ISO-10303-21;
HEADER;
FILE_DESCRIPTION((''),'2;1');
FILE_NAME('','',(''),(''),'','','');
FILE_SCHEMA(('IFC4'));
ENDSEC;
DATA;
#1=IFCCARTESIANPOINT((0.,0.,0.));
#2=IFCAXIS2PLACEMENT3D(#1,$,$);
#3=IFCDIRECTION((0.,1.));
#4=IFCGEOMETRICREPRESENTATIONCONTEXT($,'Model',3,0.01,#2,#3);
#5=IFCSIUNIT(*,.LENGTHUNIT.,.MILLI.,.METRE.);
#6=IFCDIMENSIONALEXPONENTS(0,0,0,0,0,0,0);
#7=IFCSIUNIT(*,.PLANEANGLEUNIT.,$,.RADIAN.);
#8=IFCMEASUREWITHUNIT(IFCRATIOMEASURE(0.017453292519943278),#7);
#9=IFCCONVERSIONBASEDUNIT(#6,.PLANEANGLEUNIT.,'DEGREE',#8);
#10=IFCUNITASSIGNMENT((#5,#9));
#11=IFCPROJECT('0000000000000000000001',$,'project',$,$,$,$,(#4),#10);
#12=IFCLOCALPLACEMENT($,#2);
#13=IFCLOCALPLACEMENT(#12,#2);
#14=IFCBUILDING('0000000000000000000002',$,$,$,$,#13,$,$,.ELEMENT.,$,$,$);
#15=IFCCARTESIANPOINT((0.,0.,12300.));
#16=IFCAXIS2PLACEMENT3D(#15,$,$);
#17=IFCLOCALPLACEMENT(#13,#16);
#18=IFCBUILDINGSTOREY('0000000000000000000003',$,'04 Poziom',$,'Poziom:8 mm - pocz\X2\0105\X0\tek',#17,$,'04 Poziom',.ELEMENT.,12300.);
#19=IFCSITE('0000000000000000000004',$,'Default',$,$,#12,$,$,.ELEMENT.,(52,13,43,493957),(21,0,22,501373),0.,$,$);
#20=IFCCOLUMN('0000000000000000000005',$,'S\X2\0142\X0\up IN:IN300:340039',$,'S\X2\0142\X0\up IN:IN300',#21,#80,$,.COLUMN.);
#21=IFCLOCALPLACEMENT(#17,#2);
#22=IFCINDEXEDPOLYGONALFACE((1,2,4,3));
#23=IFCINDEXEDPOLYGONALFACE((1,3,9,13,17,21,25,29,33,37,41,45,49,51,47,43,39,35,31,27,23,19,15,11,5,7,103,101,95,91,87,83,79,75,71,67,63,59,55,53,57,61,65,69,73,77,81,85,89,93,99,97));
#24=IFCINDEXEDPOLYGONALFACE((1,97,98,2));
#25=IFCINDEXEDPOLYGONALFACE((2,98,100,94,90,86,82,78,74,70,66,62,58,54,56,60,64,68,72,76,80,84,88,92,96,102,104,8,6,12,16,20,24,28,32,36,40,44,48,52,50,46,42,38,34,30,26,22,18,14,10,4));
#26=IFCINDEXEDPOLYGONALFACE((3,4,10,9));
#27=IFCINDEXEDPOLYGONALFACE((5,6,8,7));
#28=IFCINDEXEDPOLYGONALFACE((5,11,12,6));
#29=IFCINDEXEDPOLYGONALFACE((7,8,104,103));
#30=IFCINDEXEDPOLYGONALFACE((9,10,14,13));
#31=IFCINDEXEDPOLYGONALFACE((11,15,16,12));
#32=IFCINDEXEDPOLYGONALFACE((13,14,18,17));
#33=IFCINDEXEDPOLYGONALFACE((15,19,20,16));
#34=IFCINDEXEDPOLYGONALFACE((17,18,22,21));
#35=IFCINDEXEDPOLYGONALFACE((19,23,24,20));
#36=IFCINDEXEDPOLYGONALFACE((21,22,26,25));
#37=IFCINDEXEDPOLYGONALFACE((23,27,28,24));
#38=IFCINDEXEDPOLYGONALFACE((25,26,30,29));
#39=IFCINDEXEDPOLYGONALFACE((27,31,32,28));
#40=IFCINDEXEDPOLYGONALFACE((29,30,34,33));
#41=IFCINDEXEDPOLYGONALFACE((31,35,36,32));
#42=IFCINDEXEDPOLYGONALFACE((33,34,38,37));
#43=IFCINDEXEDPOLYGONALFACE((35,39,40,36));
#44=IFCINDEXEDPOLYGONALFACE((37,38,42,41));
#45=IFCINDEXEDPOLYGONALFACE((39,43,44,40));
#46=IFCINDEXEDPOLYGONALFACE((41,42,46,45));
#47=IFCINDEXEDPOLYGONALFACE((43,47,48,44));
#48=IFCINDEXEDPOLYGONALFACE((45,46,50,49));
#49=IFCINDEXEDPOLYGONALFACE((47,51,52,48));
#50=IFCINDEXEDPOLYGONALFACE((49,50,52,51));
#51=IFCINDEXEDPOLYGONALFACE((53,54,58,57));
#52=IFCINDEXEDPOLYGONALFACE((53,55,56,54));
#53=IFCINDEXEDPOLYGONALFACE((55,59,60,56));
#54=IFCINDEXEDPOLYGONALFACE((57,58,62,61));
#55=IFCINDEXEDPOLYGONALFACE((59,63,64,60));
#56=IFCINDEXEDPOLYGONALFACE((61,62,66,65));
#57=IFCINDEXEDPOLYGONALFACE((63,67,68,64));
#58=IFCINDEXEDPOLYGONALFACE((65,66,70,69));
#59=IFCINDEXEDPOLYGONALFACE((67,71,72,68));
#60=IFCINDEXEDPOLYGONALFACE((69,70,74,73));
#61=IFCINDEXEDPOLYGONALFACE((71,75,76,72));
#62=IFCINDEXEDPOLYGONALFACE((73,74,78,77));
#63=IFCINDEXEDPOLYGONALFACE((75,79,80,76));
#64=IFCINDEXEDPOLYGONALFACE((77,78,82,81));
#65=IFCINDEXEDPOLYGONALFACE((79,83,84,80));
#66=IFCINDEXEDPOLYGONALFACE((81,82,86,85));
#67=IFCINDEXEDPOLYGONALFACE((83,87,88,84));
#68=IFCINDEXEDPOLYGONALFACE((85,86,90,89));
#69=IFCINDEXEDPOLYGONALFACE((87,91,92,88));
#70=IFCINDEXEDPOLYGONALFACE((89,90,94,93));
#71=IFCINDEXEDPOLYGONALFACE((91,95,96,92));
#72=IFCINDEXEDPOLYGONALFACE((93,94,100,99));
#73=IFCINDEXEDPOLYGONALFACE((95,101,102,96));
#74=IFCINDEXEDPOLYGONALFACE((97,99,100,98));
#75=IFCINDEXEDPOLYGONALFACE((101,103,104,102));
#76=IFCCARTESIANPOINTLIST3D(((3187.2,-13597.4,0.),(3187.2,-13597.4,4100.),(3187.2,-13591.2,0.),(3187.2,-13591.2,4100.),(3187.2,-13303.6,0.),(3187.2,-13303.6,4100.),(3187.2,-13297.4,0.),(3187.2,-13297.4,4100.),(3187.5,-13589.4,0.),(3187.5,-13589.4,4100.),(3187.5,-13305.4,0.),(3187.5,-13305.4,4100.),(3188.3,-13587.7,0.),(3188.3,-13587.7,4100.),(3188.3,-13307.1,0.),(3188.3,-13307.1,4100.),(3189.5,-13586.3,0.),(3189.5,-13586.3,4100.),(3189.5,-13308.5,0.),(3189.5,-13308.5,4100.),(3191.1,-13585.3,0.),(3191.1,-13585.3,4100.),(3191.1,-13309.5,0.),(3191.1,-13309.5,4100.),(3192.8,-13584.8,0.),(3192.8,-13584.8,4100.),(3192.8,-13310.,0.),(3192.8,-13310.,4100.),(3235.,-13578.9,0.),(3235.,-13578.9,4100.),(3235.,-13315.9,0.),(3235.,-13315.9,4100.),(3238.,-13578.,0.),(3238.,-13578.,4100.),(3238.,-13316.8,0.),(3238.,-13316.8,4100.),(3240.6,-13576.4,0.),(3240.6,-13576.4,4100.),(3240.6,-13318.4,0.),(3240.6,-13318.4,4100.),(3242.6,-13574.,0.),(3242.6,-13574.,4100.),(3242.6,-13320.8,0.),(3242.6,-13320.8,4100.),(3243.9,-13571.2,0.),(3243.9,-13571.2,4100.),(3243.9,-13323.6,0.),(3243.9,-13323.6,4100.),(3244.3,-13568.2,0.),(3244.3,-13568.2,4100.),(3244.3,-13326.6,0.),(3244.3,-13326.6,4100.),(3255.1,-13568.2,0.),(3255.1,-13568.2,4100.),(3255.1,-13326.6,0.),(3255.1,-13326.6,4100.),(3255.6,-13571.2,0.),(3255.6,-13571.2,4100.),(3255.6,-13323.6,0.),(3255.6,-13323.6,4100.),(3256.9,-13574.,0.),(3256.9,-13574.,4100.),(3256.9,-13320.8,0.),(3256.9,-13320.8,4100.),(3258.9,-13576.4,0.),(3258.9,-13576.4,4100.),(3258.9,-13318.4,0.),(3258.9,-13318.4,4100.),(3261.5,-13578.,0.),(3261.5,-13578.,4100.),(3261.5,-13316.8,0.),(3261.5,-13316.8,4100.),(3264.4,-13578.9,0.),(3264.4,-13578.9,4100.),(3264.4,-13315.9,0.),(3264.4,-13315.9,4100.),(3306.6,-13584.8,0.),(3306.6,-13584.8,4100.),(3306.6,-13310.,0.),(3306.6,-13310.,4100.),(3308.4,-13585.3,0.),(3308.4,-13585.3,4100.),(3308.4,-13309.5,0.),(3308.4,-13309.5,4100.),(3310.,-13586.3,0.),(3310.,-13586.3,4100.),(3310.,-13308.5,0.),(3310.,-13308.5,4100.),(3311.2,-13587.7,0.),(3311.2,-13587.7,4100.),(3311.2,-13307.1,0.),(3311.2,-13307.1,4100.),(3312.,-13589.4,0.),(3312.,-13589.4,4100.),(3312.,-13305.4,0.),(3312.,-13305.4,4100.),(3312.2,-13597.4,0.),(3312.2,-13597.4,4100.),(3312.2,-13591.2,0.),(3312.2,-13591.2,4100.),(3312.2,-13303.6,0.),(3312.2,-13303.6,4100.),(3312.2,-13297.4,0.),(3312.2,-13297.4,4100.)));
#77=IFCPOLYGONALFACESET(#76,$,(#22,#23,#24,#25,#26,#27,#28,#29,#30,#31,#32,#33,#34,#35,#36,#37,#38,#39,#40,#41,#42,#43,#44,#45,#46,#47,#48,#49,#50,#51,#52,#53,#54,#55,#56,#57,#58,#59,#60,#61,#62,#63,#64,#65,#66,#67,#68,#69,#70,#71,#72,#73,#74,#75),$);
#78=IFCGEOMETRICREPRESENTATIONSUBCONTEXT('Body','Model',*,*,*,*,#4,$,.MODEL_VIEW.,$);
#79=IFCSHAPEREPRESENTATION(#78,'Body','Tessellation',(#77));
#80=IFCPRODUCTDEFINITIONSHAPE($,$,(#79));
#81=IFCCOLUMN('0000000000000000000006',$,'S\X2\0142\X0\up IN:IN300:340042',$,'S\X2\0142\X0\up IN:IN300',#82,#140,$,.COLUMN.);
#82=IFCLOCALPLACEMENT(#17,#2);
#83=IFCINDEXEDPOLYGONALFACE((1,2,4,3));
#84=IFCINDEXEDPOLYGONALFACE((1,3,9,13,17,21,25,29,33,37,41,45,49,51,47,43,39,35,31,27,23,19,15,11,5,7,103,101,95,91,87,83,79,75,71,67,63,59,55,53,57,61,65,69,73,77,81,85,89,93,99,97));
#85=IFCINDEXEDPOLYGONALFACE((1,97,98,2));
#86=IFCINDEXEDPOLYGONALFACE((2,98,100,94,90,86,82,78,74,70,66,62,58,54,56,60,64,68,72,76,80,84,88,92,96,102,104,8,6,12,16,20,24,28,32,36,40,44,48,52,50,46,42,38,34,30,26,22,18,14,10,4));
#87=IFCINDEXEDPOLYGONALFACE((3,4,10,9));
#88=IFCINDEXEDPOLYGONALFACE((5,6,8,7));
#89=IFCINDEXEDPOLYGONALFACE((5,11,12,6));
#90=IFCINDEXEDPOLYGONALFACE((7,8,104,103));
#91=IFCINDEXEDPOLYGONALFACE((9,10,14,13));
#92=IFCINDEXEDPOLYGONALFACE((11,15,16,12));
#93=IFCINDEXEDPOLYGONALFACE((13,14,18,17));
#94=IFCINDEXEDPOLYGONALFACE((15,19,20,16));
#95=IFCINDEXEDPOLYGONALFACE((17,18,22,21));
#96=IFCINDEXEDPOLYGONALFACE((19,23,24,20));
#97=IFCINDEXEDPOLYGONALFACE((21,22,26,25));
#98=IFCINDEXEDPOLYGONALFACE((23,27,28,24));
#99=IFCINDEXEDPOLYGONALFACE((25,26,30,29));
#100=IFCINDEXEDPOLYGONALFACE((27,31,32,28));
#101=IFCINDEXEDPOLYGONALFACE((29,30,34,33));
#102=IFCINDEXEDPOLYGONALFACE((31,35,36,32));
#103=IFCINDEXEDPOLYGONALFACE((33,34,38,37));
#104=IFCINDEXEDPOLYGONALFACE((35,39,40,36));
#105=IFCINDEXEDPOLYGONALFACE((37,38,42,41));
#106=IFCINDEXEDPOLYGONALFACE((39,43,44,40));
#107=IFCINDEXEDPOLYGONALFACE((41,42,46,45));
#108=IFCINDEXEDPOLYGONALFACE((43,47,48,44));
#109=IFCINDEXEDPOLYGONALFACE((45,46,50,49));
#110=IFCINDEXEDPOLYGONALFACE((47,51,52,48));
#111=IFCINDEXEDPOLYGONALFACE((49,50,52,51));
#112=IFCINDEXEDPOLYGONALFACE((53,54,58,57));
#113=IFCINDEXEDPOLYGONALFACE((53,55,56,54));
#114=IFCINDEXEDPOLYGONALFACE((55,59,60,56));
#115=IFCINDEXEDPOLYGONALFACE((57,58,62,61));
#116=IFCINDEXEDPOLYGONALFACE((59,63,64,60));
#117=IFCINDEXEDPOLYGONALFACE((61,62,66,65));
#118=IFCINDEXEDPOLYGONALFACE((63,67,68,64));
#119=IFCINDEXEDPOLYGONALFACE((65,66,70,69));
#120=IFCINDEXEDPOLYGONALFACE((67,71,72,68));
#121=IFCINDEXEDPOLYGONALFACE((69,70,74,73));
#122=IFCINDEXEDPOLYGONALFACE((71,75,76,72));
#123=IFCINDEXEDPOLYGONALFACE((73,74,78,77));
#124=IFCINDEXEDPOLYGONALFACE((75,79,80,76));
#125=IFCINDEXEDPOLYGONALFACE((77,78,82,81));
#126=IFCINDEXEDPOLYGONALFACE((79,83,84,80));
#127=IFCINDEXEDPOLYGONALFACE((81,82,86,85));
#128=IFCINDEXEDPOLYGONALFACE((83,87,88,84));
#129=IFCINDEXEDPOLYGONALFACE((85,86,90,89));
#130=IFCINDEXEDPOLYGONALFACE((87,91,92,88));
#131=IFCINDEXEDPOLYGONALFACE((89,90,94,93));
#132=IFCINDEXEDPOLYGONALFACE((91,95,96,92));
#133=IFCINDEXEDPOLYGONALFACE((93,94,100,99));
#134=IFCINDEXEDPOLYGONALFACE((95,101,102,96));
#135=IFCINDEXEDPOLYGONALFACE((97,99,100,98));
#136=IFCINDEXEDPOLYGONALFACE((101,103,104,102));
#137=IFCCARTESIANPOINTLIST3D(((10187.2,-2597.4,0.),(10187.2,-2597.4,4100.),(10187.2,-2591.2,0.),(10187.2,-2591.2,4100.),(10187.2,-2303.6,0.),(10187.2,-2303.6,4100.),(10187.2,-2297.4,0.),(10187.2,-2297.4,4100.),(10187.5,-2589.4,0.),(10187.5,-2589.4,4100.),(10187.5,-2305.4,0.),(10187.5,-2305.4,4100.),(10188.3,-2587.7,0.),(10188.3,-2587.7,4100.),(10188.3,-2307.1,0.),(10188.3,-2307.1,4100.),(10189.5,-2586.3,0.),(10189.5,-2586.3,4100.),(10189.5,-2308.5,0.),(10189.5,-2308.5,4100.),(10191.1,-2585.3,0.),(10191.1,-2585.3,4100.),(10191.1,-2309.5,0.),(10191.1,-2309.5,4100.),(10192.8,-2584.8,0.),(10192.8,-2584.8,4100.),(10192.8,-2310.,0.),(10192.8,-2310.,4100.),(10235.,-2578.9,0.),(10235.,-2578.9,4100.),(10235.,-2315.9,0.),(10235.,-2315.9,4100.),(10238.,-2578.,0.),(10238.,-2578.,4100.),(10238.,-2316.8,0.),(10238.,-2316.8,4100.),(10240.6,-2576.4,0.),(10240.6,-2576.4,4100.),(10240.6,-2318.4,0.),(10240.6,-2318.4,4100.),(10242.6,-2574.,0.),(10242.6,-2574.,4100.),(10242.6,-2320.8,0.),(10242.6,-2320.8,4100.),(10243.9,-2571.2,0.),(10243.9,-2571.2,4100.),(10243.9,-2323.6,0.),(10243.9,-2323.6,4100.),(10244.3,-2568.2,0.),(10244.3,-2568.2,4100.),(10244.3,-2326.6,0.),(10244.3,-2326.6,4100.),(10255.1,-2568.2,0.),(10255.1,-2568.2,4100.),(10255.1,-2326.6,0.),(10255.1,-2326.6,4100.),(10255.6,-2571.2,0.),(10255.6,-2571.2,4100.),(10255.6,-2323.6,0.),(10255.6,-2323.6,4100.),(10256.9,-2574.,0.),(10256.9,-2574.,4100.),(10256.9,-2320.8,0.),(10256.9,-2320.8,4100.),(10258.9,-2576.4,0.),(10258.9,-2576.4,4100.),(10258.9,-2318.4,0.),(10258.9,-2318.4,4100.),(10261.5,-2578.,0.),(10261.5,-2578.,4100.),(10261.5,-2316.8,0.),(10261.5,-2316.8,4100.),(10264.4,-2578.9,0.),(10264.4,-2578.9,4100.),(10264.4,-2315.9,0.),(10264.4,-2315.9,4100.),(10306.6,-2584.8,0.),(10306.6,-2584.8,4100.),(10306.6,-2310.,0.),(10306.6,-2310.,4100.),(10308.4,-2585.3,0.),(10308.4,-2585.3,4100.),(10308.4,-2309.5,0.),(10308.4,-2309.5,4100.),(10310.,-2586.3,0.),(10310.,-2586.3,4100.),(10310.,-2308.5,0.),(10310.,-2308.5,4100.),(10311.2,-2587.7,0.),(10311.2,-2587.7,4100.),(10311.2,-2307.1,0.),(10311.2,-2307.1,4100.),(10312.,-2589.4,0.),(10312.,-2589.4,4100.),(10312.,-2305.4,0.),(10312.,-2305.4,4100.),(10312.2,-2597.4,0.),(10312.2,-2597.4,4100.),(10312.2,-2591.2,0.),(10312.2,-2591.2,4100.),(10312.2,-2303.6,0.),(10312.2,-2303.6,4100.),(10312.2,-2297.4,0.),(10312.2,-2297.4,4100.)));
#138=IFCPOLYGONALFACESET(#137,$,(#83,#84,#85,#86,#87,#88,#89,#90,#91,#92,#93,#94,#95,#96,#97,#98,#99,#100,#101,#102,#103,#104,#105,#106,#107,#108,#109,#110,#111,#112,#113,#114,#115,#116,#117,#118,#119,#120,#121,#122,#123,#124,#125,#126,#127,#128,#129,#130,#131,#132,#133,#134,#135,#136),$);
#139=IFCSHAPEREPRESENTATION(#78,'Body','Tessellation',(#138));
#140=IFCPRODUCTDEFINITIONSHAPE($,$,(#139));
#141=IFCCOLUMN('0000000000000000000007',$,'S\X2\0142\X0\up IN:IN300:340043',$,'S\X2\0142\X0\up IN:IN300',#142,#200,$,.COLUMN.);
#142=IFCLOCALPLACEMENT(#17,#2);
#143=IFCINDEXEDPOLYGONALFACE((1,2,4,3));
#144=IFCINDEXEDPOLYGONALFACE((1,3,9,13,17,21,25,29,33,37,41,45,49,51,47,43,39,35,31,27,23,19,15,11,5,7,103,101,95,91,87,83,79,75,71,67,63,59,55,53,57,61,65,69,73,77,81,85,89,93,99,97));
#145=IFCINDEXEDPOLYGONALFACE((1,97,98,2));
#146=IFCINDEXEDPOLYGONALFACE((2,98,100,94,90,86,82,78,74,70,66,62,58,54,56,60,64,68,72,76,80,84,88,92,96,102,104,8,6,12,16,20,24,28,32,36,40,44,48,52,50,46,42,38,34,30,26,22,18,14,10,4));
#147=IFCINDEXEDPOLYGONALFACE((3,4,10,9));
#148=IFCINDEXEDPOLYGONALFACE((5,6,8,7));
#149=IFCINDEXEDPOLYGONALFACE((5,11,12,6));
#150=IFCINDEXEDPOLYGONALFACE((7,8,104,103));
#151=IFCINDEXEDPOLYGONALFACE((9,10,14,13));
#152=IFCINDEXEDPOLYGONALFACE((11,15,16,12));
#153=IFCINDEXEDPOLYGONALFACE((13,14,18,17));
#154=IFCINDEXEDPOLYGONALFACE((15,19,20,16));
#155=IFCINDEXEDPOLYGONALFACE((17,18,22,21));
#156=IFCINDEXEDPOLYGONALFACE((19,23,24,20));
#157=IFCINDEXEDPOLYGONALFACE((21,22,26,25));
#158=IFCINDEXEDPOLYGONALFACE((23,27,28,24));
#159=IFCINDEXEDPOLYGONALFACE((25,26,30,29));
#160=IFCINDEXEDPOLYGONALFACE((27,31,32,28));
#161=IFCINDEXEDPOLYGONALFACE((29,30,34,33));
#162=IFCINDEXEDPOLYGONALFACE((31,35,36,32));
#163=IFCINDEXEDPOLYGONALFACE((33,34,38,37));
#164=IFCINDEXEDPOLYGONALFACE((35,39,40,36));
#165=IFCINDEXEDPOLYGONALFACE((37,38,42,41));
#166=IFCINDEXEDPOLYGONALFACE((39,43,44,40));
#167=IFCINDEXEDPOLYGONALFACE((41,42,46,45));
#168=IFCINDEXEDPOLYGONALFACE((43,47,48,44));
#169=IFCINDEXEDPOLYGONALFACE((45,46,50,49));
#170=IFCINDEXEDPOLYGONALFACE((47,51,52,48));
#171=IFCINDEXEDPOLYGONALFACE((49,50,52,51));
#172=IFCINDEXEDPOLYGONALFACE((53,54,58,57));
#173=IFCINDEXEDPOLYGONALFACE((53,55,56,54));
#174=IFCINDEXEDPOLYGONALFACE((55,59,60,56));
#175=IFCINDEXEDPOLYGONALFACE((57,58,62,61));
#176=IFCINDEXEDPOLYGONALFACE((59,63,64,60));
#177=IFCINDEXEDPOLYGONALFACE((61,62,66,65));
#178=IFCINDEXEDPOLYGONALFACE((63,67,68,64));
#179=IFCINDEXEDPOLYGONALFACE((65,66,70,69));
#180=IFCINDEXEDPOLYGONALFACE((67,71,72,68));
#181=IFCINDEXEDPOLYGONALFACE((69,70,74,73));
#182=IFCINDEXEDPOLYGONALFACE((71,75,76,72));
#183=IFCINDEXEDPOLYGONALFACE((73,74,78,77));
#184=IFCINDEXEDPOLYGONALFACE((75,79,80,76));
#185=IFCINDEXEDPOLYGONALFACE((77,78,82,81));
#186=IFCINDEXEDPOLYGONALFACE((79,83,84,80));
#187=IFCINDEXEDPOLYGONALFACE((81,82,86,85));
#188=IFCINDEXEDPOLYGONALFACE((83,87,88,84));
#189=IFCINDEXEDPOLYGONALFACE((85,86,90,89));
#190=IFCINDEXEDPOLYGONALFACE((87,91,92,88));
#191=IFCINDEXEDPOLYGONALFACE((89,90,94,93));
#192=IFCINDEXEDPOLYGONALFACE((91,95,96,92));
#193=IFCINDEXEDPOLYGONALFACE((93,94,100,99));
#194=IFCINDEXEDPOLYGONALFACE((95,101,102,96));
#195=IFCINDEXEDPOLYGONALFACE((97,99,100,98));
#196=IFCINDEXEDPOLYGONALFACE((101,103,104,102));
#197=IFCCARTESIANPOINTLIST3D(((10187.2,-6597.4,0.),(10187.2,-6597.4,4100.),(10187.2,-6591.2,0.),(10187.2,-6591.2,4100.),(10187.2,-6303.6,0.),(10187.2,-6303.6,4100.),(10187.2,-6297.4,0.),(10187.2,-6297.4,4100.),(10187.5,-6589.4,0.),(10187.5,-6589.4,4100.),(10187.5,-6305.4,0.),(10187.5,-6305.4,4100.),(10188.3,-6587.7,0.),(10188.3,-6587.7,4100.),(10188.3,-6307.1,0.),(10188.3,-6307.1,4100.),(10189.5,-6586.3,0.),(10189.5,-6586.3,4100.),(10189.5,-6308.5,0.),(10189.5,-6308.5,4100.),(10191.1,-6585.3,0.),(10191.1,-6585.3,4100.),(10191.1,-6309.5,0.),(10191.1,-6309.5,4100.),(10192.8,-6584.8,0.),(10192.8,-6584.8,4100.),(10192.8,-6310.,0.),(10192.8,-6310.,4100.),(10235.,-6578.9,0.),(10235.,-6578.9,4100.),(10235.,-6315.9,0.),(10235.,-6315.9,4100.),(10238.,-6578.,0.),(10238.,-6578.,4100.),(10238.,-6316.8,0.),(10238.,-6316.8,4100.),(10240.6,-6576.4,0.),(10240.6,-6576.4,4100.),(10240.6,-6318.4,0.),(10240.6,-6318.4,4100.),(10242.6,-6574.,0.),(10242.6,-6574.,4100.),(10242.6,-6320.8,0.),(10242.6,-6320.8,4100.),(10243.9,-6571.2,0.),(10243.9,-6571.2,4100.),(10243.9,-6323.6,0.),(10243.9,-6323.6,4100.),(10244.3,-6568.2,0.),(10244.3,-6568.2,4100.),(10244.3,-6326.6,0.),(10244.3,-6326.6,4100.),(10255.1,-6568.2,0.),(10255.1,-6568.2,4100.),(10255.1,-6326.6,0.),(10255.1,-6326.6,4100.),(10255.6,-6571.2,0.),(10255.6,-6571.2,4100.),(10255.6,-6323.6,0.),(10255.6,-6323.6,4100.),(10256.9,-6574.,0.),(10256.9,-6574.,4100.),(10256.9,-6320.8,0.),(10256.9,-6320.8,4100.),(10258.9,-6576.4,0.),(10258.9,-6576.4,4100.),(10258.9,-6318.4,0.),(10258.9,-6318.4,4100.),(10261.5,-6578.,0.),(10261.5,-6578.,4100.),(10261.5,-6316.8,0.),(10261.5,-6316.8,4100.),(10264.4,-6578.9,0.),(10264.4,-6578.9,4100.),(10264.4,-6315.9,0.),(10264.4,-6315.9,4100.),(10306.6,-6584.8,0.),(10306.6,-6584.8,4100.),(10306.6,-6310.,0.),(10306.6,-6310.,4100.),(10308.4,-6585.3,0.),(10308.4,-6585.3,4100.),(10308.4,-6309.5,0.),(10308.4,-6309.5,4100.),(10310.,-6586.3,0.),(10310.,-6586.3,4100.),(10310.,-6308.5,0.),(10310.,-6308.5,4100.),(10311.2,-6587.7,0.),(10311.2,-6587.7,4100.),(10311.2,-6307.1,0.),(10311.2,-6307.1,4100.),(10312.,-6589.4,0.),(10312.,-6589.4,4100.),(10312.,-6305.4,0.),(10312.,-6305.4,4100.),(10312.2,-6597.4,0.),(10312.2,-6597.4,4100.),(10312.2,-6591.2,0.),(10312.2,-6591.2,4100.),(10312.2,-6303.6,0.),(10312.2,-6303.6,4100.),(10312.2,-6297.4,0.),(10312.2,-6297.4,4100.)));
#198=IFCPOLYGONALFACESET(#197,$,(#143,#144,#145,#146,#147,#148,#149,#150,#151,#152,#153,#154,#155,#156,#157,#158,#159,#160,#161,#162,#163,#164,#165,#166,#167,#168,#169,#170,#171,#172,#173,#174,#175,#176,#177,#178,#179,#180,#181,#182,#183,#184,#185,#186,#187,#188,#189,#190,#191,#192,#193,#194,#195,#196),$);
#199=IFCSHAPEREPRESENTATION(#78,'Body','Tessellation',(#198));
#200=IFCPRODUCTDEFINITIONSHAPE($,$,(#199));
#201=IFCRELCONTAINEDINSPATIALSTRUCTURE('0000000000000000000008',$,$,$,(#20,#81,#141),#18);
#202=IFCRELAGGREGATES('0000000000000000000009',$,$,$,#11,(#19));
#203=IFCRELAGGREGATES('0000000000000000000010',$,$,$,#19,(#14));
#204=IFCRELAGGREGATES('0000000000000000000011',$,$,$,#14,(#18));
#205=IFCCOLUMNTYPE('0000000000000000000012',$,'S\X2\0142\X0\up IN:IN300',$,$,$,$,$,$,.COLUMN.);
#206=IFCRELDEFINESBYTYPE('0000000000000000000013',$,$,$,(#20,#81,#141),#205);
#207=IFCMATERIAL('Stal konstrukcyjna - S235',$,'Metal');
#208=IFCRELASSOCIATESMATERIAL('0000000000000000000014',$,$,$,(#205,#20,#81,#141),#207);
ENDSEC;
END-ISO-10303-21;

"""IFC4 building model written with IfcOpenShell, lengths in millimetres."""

from ifc_helpers import new_model, entity, si_unit, converted_unit, direction, frame, origin, place, context, subcontext, project, spatial, line, arc, indexed_curve, outline, extrude, source, transform, mapped, material, type_object, type_shapes, element, save


model = new_model("IFC4")

# Units and contexts
model_context = context("Model", 3, precision=0.01, world=origin(), true_north=direction((0.0, 1.0)))
body_context = subcontext(model_context, "Body", "Model", "MODEL_VIEW")
ifc_project = project(units=[si_unit("LENGTHUNIT", "METRE", prefix="MILLI"), converted_unit("PLANEANGLEUNIT", "DEGREE", entity("IfcRatioMeasure", 0.017453292519943278), si_unit("PLANEANGLEUNIT", "RADIAN"), dimensions=[0, 0, 0, 0, 0, 0, 0])], contexts=[model_context])

# Site, building, storey
site_placement = place(None, origin())
site = spatial("IfcSite", under=ifc_project, at=site_placement, Name="Default", CompositionType="ELEMENT", RefLatitude=(52, 13, 43, 493957), RefLongitude=(21, 0, 22, 501373), RefElevation=0.0)
building_placement = place(site_placement, origin())
building = spatial("IfcBuilding", under=site, at=building_placement, CompositionType="ELEMENT")
storey_placement = place(building_placement, frame((0.0, 0.0, 12300.0)))
storey = spatial("IfcBuildingStorey", under=building, at=storey_placement, Name="04 Poziom", ObjectType="Poziom:8 mm - początek", LongName="04 Poziom", CompositionType="ELEMENT", Elevation=12300.0)

# Columns
ifc_material = material(Name="Stal konstrukcyjna - S235", Category="Metal")
column_type = type_object("IfcColumnType", Name="Słup IN:IN300", PredefinedType="COLUMN", material=ifc_material)
shared_shape_1 = source(origin(), body_context, "Body", "SweptSolid", [
    extrude(outline(indexed_curve([(143.8, -62.5), (150.0, -62.5), (150.0, 62.5), (143.8, 62.5), (139.6, 60.9), (137.4, 56.9), (131.5, 14.7), (127.9, 8.1), (120.8, 5.4), (-120.8, 5.4), (-127.9, 8.1), (-131.5, 14.7), (-137.4, 56.9), (-139.6, 60.9), (-143.8, 62.5), (-150.0, 62.5), (-150.0, -62.5), (-143.8, -62.5), (-139.6, -60.9), (-137.4, -56.9), (-131.5, -14.7), (-127.9, -8.1), (-120.8, -5.4), (120.8, -5.4), (127.9, -8.1), (131.5, -14.7), (137.4, -56.9), (139.6, -60.9)], segments=[line(1, 2, 3, 4), arc(4, 5, 6), line(6, 7), arc(7, 8, 9), line(9, 10), arc(10, 11, 12), line(12, 13), arc(13, 14, 15), line(15, 16, 17, 18), arc(18, 19, 20), line(20, 21), arc(21, 22, 23), line(23, 24), arc(24, 25, 26), line(26, 27), arc(27, 28, 1)], self_intersect=False)), frame((0.0, 0.0, 12300.0), z_axis=(0.0, 0.0, 1.0), x_axis=(0.0, -1.0, 0.0)), (0.0, 0.0, 1.0), 4100.0),
])
type_shapes(column_type, [shared_shape_1])
for number, where, name in (
    (1, (3249.7, -13447.4, -12300.0), "Słup IN:IN300:340039"),
    (2, (10249.7, -2447.4, -12300.0), "Słup IN:IN300:340042"),
    (3, (10249.7, -6447.4, -12300.0), "Słup IN:IN300:340043"),
):
    element("IfcColumn", number, at=place(storey_placement, frame(where)), inside=storey, type_object=column_type, material=ifc_material, Name=name, ObjectType="Słup IN:IN300", PredefinedType="COLUMN", context=body_context, shape_type="MappedRepresentation", body=[
        mapped(shared_shape_1, transform((0.0, 0.0, 0.0), scale=1.0)),
    ])

save(model, "model.ifc")
